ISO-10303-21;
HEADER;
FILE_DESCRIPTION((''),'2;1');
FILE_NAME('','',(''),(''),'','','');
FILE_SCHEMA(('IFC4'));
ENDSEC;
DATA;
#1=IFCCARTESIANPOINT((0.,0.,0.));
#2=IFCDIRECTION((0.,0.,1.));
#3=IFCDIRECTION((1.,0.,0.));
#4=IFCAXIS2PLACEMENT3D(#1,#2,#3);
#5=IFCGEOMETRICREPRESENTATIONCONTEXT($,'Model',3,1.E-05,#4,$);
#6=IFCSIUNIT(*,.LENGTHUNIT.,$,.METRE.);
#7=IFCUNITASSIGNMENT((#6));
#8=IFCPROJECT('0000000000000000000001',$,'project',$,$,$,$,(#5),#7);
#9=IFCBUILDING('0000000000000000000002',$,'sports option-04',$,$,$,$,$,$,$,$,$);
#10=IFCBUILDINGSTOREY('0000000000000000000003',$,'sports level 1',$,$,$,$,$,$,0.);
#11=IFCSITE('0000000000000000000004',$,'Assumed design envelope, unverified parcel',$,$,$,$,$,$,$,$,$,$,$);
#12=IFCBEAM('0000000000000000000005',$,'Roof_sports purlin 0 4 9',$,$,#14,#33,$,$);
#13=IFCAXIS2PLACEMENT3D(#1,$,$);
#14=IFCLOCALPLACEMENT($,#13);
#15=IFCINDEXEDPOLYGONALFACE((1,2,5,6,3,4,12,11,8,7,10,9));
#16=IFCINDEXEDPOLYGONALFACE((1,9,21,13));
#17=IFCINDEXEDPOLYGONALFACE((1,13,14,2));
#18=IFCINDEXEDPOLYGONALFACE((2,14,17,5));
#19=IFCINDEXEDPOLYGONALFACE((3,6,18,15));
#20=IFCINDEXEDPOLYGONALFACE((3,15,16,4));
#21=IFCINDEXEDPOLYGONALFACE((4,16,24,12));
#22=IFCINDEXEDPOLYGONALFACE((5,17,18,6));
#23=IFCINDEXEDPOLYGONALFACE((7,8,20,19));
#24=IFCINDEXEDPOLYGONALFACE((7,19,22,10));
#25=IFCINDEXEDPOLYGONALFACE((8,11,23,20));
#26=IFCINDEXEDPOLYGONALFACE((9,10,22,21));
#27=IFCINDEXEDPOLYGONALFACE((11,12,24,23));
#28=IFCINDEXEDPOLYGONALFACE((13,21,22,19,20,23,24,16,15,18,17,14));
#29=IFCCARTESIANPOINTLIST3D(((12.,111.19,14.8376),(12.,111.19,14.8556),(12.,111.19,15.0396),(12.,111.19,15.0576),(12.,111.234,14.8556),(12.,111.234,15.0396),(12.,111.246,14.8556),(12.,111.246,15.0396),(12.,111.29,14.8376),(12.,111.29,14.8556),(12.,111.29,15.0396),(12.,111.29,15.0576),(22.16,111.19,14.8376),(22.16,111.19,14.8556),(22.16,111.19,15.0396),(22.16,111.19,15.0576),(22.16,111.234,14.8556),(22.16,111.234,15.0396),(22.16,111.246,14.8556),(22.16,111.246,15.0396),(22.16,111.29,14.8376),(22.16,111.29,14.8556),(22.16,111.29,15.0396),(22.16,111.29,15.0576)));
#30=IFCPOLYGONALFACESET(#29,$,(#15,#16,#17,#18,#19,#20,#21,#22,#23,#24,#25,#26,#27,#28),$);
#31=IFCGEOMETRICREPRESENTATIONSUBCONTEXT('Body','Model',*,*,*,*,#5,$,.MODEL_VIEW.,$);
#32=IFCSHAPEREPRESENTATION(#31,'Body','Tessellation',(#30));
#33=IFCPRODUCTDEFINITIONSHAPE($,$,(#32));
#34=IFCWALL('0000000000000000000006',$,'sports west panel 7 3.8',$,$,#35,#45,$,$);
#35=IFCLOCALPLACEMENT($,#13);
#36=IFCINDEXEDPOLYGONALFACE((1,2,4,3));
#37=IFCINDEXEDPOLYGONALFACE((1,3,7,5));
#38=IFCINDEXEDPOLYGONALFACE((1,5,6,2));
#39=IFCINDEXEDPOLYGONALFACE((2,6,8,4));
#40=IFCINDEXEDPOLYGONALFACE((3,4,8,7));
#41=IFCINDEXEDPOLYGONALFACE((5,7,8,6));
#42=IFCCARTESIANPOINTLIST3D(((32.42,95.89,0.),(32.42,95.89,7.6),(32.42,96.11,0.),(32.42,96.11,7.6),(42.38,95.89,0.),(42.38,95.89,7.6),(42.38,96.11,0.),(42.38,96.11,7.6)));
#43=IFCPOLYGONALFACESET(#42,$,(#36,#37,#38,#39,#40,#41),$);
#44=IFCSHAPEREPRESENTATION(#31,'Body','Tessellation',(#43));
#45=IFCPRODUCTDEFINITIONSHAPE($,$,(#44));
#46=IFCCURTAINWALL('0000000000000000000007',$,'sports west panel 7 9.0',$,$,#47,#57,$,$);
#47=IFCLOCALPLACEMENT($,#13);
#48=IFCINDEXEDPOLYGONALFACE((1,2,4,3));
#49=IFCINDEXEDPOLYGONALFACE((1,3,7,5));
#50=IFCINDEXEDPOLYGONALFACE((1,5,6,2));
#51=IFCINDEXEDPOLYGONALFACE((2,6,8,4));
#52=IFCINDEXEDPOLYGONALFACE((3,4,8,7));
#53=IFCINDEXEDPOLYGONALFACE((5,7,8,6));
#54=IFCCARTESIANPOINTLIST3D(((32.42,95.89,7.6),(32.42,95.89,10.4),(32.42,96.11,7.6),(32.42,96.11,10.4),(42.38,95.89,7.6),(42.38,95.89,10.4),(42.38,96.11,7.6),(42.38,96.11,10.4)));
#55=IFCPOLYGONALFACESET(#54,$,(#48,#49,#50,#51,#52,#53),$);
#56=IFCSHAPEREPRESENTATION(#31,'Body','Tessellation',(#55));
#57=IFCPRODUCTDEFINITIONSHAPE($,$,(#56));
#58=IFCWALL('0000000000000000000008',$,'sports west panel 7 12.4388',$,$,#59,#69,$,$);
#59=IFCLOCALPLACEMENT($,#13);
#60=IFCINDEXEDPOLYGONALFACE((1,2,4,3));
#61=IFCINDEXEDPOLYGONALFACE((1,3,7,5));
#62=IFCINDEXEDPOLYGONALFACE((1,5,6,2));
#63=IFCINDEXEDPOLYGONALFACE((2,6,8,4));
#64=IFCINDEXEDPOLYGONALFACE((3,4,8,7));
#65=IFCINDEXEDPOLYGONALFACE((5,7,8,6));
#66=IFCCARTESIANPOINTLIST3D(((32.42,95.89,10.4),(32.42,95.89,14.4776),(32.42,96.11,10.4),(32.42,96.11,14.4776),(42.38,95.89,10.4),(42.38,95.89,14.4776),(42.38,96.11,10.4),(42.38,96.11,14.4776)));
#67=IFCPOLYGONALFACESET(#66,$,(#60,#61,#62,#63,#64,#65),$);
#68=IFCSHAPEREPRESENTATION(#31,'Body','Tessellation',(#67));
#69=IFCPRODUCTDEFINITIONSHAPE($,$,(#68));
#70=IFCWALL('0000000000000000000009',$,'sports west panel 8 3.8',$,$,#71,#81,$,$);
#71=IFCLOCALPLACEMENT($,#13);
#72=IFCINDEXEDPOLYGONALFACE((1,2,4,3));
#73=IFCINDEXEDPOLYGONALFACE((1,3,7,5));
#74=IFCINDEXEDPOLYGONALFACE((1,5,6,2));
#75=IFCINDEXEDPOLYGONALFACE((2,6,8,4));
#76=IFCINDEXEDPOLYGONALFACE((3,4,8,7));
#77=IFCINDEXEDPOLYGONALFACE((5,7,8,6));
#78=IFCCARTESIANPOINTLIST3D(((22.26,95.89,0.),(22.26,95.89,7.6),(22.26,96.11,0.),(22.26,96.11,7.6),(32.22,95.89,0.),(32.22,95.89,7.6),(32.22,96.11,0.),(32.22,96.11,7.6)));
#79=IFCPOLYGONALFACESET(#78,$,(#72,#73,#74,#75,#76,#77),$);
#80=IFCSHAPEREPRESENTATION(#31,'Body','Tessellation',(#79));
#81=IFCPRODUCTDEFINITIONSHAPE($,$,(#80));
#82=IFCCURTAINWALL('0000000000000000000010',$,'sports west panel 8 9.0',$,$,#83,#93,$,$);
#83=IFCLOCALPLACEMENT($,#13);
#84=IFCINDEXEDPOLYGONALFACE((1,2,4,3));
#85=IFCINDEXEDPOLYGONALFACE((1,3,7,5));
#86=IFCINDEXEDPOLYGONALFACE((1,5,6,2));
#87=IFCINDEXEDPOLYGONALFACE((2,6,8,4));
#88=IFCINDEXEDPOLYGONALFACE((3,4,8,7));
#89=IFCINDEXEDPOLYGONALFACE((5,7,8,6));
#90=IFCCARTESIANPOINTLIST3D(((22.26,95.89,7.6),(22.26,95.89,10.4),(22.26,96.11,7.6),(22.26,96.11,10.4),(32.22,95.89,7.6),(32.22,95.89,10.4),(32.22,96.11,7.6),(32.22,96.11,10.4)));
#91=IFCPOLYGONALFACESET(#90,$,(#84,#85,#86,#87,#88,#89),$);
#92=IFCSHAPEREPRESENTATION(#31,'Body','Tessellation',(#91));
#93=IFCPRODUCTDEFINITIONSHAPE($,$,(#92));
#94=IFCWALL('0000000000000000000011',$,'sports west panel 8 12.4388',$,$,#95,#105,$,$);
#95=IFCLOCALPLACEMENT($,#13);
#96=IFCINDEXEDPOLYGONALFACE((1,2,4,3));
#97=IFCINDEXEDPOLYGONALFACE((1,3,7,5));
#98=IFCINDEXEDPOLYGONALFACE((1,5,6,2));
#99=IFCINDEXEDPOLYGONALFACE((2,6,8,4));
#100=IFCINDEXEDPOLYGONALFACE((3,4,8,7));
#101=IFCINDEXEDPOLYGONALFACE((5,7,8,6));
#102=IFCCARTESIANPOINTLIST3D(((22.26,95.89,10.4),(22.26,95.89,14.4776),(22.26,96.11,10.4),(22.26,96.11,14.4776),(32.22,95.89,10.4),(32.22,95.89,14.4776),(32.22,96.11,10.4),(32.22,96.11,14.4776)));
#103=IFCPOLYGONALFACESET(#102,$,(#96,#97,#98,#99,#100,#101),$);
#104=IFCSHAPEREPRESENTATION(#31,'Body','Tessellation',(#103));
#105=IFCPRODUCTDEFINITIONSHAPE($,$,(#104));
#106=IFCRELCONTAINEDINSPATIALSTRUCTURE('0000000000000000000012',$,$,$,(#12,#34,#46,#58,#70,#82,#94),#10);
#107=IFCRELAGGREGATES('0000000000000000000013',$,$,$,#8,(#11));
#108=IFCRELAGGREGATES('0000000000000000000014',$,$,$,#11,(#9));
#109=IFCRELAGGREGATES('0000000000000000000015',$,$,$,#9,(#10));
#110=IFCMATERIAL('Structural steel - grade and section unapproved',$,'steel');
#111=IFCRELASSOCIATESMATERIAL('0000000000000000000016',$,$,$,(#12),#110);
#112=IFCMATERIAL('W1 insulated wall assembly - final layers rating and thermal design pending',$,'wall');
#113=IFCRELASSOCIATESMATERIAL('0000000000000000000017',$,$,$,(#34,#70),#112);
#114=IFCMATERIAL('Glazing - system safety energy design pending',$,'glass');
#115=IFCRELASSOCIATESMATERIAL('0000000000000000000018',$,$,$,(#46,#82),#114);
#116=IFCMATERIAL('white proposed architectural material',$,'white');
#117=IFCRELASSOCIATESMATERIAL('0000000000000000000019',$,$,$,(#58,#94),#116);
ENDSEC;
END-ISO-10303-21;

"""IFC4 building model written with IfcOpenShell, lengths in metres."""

from ifc_helpers import new_model, si_unit, frame, origin_with_axes, place, context, subcontext, project, spatial, rectangle, i_section, extrude, material, element, save


model = new_model("IFC4")

# Units and contexts
model_context = context("Model", 3, precision=1e-05, world=origin_with_axes())
body_context = subcontext(model_context, "Body", "Model", "MODEL_VIEW")
ifc_project = project(units=[si_unit("LENGTHUNIT", "METRE")], contexts=[model_context])

# Site, building, storey
site = spatial("IfcSite", under=ifc_project, Name="Assumed design envelope, unverified parcel")
building = spatial("IfcBuilding", under=site, Name="sports option-04")
storey = spatial("IfcBuildingStorey", under=building, Name="sports level 1", Elevation=0.0)

# Shared definitions
ifc_material_1 = material(Name="Structural steel - grade and section unapproved", Category="steel")

# Beam
for number, where, z_axis, x_axis, name in (
    (1, (22.16, 111.24, 14.9476), (-1.0, 0.0, 0.0), (0.0, -1.0, 0.0), "Roof_sports purlin 0 4 9"),
):
    element("IfcBeam", number, at=place(None, frame(where, z_axis=z_axis, x_axis=x_axis)), inside=storey, material=ifc_material_1, Name=name, context=body_context, shape_type="SweptSolid", body=[
        extrude(i_section(OverallWidth=0.1, OverallDepth=0.22, WebThickness=0.012, FlangeThickness=0.018, FilletRadius=0.0), origin_with_axes(), (0.0, 0.0, 1.0), 10.16),
    ])

# Wall
ifc_material_2 = material(Name="W1 insulated wall assembly - final layers rating and thermal design pending", Category="wall")
wall_1_placement = place(None, frame((37.4, 96.0, 0.0), z_axis=(0.0, 0.0, 1.0), x_axis=(0.0, 1.0, 0.0)))
element("IfcWall", 2, at=wall_1_placement, inside=storey, material=ifc_material_2, Name="sports west panel 7 3.8", context=body_context, shape_type="SweptSolid", body=[
    extrude(rectangle(XDim=0.22, YDim=9.96), origin_with_axes(), (0.0, 0.0, 1.0), 7.6),
])

# Curtain wall
ifc_material_3 = material(Name="Glazing - system safety energy design pending", Category="glass")
curtain_wall_1_placement = place(None, frame((37.4, 96.0, 7.6), z_axis=(0.0, 0.0, 1.0), x_axis=(0.0, 1.0, 0.0)))
element("IfcCurtainWall", 3, at=curtain_wall_1_placement, inside=storey, material=ifc_material_3, Name="sports west panel 7 9.0", context=body_context, shape_type="SweptSolid", body=[
    extrude(rectangle(XDim=0.22, YDim=9.96), origin_with_axes(), (0.0, 0.0, 1.0), 2.8),
])

# Walls
ifc_material_4 = material(Name="white proposed architectural material", Category="white")
wall_2_placement = place(None, frame((37.4, 96.0, 10.4), z_axis=(0.0, 0.0, 1.0), x_axis=(0.0, 1.0, 0.0)))
element("IfcWall", 4, at=wall_2_placement, inside=storey, material=ifc_material_4, Name="sports west panel 7 12.4388", context=body_context, shape_type="SweptSolid", body=[
    extrude(rectangle(XDim=0.22, YDim=9.96), origin_with_axes(), (0.0, 0.0, 1.0), 4.0776),
])
wall_3_placement = place(None, frame((27.24, 96.0, 0.0), z_axis=(0.0, 0.0, 1.0), x_axis=(0.0, 1.0, 0.0)))
element("IfcWall", 5, at=wall_3_placement, inside=storey, material=ifc_material_2, Name="sports west panel 8 3.8", context=body_context, shape_type="SweptSolid", body=[
    extrude(rectangle(XDim=0.22, YDim=9.96), origin_with_axes(), (0.0, 0.0, 1.0), 7.6),
])

# Curtain wall
curtain_wall_2_placement = place(None, frame((27.24, 96.0, 7.6), z_axis=(0.0, 0.0, 1.0), x_axis=(0.0, 1.0, 0.0)))
element("IfcCurtainWall", 6, at=curtain_wall_2_placement, inside=storey, material=ifc_material_3, Name="sports west panel 8 9.0", context=body_context, shape_type="SweptSolid", body=[
    extrude(rectangle(XDim=0.22, YDim=9.96), origin_with_axes(), (0.0, 0.0, 1.0), 2.8),
])

# Wall
wall_4_placement = place(None, frame((27.24, 96.0, 10.4), z_axis=(0.0, 0.0, 1.0), x_axis=(0.0, 1.0, 0.0)))
element("IfcWall", 7, at=wall_4_placement, inside=storey, material=ifc_material_4, Name="sports west panel 8 12.4388", context=body_context, shape_type="SweptSolid", body=[
    extrude(rectangle(XDim=0.22, YDim=9.96), origin_with_axes(), (0.0, 0.0, 1.0), 4.0776),
])

save(model, "model.ifc")
